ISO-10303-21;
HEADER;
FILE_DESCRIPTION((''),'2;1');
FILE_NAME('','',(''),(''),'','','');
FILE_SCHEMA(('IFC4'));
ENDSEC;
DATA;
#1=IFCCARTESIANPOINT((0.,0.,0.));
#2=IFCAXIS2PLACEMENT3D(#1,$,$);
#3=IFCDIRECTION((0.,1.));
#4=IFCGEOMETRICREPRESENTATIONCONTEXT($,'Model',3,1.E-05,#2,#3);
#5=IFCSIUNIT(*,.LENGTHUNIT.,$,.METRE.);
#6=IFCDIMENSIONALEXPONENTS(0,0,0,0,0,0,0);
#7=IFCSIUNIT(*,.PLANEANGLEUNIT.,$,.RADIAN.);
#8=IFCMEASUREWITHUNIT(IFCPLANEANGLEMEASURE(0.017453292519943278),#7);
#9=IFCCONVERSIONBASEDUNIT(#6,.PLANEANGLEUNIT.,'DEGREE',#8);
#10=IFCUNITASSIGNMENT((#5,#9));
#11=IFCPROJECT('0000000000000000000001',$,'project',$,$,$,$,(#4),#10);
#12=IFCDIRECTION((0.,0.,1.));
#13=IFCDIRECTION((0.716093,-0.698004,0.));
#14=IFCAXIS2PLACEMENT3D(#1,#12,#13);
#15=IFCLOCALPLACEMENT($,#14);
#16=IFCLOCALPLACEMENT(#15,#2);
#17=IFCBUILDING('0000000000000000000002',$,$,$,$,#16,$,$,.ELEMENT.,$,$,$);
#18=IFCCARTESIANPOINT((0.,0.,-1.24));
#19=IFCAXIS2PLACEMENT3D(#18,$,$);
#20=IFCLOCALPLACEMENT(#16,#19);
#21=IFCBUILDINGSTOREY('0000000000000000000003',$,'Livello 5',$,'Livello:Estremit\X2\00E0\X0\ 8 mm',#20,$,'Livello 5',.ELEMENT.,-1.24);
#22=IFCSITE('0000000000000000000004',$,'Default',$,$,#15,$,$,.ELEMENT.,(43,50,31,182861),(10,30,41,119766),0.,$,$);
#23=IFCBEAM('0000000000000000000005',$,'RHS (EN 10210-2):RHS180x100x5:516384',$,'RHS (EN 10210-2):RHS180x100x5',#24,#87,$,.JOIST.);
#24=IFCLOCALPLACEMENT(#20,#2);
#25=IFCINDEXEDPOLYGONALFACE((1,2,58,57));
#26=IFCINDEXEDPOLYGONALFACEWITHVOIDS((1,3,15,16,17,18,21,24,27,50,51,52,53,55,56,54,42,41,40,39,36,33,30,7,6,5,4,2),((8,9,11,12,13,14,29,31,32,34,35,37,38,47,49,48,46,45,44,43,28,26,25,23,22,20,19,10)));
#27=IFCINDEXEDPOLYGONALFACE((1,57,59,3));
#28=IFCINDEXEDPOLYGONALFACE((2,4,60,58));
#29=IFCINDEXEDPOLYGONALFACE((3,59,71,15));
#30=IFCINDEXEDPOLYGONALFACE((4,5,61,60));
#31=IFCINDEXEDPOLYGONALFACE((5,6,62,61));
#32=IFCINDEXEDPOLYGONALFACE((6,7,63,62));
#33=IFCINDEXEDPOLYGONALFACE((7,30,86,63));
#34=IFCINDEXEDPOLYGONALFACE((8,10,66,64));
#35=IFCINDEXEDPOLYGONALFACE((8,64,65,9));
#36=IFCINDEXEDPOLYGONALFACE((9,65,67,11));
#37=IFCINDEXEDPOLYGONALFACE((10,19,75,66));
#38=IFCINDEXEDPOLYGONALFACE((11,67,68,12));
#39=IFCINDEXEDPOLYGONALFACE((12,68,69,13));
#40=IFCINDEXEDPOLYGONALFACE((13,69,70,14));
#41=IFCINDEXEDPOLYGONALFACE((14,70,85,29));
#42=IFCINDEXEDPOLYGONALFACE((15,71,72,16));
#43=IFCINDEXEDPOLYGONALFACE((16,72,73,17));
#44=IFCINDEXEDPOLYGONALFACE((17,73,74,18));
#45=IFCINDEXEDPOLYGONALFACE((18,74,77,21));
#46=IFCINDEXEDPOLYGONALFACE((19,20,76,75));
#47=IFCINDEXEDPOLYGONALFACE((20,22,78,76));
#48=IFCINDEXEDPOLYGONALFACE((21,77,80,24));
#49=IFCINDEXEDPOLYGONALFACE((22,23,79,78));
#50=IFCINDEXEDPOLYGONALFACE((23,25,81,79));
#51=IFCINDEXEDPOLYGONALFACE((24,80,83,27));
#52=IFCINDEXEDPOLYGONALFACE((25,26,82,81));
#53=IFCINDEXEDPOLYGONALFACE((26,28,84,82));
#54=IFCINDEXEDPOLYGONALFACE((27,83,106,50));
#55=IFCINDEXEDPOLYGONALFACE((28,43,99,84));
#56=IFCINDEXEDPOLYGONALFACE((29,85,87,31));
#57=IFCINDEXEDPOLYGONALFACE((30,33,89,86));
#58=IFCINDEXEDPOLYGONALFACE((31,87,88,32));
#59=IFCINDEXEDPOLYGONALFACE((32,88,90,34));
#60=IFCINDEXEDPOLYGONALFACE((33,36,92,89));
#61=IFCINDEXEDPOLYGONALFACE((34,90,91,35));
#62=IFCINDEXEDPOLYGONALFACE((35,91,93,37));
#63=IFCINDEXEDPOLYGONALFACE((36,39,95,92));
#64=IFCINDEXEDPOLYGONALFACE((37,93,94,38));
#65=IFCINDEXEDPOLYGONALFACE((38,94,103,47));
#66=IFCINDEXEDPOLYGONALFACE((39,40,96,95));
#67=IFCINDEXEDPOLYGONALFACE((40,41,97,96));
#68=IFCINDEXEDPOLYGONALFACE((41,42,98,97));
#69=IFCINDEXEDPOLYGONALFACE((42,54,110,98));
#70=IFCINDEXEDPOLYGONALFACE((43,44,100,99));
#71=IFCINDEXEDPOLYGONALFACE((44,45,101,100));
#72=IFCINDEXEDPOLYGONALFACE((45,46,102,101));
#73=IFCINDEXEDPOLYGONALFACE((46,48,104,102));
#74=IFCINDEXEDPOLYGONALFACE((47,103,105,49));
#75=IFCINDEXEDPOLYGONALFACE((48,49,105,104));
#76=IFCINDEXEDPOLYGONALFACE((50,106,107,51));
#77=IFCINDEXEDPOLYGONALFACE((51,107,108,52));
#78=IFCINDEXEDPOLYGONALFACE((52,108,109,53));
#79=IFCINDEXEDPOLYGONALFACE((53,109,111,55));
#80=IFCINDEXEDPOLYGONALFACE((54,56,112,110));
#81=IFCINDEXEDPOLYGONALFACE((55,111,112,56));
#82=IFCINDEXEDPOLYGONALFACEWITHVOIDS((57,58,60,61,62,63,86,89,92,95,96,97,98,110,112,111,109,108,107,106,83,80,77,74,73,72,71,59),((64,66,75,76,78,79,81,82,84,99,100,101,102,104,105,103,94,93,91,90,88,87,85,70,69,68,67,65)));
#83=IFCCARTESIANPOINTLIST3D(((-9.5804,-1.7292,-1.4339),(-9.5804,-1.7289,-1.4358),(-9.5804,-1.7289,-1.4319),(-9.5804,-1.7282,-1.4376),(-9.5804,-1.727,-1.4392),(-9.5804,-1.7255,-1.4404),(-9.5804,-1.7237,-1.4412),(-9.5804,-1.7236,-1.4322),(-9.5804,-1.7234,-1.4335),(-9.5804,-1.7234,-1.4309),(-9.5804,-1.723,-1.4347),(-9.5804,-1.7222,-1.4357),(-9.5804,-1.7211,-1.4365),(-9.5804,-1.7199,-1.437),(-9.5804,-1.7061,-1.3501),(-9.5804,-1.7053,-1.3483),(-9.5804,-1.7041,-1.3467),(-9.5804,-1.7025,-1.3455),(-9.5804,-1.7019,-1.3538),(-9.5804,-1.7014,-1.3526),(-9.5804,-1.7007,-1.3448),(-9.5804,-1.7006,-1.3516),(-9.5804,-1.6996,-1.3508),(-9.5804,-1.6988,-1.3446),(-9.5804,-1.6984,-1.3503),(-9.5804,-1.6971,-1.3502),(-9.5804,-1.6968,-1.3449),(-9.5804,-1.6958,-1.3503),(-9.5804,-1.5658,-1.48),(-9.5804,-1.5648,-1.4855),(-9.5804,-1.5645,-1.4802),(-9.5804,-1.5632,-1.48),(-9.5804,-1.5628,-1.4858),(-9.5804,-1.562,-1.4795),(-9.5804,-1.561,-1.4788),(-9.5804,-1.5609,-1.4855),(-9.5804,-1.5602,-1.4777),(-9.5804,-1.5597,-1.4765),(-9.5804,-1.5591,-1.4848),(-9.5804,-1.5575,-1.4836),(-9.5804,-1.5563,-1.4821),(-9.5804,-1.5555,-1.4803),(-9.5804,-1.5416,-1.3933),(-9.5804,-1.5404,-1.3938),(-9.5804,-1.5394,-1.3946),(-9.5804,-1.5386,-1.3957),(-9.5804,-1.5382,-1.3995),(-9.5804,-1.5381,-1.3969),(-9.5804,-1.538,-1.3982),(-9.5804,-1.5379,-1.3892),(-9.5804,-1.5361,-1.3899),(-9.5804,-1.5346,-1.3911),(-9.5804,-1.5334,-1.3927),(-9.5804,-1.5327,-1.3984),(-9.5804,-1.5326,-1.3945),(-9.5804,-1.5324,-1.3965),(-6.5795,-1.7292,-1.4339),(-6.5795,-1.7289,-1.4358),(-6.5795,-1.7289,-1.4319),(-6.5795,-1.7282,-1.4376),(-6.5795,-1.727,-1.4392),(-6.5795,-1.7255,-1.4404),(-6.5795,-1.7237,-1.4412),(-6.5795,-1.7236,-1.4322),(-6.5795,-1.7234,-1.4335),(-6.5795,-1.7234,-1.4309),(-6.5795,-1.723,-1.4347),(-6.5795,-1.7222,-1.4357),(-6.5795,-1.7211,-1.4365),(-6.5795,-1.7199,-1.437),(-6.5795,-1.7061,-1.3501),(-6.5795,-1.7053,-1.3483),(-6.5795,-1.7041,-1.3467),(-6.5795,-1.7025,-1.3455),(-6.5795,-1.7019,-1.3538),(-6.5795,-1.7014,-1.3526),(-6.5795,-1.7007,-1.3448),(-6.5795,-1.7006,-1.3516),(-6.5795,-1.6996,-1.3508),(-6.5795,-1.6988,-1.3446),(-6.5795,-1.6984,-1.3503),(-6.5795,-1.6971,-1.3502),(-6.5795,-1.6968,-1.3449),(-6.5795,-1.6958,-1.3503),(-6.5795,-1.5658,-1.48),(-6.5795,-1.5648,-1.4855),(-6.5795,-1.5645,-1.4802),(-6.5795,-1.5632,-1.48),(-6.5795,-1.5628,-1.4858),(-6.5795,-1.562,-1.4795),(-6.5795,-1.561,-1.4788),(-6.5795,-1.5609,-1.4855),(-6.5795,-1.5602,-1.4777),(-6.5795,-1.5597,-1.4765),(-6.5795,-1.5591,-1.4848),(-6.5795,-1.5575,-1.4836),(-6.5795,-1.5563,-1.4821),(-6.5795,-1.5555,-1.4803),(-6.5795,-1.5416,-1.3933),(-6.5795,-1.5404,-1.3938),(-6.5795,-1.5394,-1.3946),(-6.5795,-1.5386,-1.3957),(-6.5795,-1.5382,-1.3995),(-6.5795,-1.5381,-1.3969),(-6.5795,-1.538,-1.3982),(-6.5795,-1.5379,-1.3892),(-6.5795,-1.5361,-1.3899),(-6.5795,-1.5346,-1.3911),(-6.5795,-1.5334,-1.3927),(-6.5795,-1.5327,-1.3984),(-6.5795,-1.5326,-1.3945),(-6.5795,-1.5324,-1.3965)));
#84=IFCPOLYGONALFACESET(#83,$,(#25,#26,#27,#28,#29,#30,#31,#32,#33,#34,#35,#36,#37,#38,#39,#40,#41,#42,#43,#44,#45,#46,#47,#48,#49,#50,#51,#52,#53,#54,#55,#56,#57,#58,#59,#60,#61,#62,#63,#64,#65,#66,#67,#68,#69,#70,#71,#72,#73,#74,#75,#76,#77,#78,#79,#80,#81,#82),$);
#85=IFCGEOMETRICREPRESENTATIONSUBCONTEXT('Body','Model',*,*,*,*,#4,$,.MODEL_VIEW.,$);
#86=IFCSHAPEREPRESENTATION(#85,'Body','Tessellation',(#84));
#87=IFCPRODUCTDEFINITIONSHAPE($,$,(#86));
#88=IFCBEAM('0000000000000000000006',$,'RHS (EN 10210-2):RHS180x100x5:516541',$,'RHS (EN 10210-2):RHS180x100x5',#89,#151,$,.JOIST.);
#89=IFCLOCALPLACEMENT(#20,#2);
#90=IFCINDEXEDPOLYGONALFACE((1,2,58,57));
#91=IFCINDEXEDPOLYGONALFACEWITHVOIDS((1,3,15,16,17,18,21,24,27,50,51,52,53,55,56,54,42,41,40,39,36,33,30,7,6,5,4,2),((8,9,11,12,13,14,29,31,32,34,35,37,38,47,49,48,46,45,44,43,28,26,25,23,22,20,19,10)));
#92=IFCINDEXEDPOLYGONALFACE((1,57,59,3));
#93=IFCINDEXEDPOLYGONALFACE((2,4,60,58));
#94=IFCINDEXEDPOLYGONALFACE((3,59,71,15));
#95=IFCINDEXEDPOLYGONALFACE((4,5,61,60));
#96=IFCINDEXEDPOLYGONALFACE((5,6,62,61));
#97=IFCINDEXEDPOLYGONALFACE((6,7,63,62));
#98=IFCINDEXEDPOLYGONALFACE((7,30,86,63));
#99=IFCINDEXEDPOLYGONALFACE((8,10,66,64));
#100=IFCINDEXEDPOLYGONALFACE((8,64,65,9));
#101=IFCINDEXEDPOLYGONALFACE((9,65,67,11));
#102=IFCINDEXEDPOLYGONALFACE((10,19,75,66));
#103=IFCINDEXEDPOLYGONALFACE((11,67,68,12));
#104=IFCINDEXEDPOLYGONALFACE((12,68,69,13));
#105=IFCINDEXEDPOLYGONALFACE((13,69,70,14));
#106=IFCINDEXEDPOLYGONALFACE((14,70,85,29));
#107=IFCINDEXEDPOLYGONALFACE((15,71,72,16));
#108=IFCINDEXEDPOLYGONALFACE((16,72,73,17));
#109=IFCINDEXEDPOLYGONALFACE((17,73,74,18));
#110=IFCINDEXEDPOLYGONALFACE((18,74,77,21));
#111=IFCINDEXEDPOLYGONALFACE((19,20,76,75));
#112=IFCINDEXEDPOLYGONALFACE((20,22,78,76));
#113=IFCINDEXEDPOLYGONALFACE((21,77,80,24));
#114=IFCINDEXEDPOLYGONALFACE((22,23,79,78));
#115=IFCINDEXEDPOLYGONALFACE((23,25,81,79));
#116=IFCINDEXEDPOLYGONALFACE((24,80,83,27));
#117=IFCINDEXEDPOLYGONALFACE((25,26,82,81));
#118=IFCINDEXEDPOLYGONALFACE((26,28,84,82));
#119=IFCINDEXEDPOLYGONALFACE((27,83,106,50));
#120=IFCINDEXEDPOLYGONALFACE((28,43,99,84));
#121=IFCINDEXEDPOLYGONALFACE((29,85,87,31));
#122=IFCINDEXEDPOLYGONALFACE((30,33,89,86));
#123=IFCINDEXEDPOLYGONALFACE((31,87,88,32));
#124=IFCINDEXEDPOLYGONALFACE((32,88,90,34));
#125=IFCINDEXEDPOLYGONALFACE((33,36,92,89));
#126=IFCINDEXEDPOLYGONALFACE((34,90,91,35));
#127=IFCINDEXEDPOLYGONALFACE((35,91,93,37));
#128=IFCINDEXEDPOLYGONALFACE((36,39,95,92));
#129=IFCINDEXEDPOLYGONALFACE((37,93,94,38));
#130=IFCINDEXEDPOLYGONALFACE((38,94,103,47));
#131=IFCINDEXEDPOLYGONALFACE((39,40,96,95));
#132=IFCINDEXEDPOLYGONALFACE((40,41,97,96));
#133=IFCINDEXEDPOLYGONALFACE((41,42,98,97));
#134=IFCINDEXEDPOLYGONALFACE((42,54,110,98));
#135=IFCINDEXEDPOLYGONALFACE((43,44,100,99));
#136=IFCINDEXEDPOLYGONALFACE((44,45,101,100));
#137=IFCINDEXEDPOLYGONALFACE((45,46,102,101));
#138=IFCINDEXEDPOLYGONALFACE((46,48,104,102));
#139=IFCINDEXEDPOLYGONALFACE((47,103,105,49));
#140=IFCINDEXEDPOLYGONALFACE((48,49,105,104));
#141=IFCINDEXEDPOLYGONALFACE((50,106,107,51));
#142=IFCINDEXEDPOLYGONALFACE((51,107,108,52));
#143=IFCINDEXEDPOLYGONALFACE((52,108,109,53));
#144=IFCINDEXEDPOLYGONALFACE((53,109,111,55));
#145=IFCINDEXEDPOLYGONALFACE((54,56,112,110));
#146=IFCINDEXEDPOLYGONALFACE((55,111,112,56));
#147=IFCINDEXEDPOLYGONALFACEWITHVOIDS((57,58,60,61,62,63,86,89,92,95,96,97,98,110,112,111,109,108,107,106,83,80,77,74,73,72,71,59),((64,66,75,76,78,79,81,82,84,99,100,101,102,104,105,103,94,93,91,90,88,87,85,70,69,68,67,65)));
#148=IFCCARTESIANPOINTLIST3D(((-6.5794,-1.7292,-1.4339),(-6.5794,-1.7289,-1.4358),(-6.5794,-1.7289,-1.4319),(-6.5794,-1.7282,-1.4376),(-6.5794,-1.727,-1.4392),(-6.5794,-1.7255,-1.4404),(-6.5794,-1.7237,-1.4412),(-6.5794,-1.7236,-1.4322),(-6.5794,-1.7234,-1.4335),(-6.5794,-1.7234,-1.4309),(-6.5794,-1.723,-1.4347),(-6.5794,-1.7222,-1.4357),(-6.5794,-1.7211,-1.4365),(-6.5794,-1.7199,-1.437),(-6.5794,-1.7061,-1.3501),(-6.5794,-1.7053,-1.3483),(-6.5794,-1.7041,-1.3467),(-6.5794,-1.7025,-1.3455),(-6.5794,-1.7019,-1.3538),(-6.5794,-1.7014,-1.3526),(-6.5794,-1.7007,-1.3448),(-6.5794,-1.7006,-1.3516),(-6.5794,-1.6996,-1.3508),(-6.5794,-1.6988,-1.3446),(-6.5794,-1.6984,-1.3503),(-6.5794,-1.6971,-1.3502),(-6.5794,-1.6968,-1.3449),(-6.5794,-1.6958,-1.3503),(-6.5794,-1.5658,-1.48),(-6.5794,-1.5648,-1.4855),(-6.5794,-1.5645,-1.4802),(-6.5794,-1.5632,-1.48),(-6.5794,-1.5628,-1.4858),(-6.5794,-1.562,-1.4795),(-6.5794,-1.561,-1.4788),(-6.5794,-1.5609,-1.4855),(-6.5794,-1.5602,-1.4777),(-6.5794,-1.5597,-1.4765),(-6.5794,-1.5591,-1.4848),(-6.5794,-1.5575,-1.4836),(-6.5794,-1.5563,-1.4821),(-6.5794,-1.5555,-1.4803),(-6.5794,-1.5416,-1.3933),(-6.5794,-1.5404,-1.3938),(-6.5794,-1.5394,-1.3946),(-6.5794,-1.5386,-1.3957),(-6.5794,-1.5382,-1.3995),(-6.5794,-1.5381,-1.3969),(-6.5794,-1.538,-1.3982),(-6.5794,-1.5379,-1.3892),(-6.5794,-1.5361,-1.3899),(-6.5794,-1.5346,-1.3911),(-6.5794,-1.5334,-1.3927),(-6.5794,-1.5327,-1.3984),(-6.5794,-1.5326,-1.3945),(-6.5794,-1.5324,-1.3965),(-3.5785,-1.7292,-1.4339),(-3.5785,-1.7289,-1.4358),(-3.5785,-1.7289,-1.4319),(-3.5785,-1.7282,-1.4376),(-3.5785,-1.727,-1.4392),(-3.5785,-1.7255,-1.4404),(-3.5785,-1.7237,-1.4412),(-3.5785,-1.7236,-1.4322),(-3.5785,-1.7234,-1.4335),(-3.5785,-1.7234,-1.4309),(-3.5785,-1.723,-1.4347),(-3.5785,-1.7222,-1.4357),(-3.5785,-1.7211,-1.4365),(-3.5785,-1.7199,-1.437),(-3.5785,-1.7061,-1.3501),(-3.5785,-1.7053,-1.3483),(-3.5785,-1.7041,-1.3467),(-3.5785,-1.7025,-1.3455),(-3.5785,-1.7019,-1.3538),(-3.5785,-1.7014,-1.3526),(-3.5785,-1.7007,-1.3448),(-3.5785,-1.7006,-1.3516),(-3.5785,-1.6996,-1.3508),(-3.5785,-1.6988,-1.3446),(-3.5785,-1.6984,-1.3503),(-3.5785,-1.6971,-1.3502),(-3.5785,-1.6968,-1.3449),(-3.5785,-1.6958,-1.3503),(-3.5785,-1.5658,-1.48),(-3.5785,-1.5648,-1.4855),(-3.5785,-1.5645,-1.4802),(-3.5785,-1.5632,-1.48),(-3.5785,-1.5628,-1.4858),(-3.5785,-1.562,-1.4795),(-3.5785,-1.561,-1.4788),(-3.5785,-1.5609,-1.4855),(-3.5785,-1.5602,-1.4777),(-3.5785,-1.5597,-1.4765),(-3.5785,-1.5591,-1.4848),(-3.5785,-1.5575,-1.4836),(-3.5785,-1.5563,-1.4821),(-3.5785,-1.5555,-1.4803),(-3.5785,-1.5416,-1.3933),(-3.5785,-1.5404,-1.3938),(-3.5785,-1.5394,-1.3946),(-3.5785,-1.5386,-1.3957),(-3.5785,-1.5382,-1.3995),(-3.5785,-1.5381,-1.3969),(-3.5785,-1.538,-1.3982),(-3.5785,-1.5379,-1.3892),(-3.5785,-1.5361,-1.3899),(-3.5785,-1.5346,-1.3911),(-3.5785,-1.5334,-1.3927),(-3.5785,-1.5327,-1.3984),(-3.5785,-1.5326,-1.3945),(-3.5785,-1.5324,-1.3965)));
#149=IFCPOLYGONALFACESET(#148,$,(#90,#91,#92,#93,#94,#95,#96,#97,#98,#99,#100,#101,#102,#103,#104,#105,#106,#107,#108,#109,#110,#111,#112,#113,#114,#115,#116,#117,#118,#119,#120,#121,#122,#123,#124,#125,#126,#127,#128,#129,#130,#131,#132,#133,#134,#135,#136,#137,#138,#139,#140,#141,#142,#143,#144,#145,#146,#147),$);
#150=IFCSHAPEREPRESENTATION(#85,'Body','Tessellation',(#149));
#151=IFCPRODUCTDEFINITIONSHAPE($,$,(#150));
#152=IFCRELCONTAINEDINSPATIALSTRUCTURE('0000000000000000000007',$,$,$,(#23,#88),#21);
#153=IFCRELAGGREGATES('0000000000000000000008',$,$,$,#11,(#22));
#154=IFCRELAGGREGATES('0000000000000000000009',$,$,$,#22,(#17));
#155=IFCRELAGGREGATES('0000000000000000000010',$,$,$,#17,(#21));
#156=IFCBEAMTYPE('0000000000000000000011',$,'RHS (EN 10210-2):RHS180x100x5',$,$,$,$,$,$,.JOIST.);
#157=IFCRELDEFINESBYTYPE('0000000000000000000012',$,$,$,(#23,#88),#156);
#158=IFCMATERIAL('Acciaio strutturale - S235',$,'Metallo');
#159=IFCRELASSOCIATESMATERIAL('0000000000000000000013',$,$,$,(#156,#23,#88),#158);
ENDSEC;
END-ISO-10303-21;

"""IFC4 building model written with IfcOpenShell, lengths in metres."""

from ifc_helpers import new_model, entity, si_unit, converted_unit, direction, frame, origin, place, context, subcontext, project, spatial, line, arc, indexed_curve, outline, extrude, source, transform, mapped, material, type_object, type_shapes, element, save


model = new_model("IFC4")

# Units and contexts
model_context = context("Model", 3, precision=1e-05, world=origin(), true_north=direction((0.0, 1.0)))
body_context = subcontext(model_context, "Body", "Model", "MODEL_VIEW")
ifc_project = project(units=[si_unit("LENGTHUNIT", "METRE"), converted_unit("PLANEANGLEUNIT", "DEGREE", entity("IfcPlaneAngleMeasure", 0.017453292519943278), si_unit("PLANEANGLEUNIT", "RADIAN"), dimensions=[0, 0, 0, 0, 0, 0, 0])], contexts=[model_context])

# Site, building, storey
site_placement = place(None, frame((0.0, 0.0, 0.0), z_axis=(0.0, 0.0, 1.0), x_axis=(0.716093, -0.698004, 0.0)))
site = spatial("IfcSite", under=ifc_project, at=site_placement, Name="Default", CompositionType="ELEMENT", RefLatitude=(43, 50, 31, 182861), RefLongitude=(10, 30, 41, 119766), RefElevation=0.0)
building_placement = place(site_placement, origin())
building = spatial("IfcBuilding", under=site, at=building_placement, CompositionType="ELEMENT")
storey_placement = place(building_placement, frame((0.0, 0.0, -1.24)))
storey = spatial("IfcBuildingStorey", under=building, at=storey_placement, Name="Livello 5", ObjectType="Livello:Estremità 8 mm", LongName="Livello 5", CompositionType="ELEMENT", Elevation=-1.24)

# Beams
ifc_material = material(Name="Acciaio strutturale - S235", Category="Metallo")
beam_type_1 = type_object("IfcBeamType", Name="RHS (EN 10210-2):RHS180x100x5", PredefinedType="JOIST", material=ifc_material)
shared_shape_1 = source(origin(), body_context, "Body", "SweptSolid", [
    extrude(outline(indexed_curve([(-0.05, -0.0825), (-0.0478, -0.0878), (-0.0425, -0.09), (0.0425, -0.09), (0.0478, -0.0878), (0.05, -0.0825), (0.05, 0.0825), (0.0478, 0.0878), (0.0425, 0.09), (-0.0425, 0.09), (-0.0478, 0.0878), (-0.05, 0.0825)], segments=[arc(1, 2, 3), line(3, 4), arc(4, 5, 6), line(6, 7), arc(7, 8, 9), line(9, 10), arc(10, 11, 12), line(12, 1)], self_intersect=False), holes=[indexed_curve([(0.04, -0.085), (-0.04, -0.085), (-0.0435, -0.0835), (-0.045, -0.08), (-0.045, 0.08), (-0.0435, 0.0835), (-0.04, 0.085), (0.04, 0.085), (0.0435, 0.0835), (0.045, 0.08), (0.045, -0.08), (0.0435, -0.0835)], segments=[line(1, 2), arc(2, 3, 4), line(4, 5), arc(5, 6, 7), line(7, 8), arc(8, 9, 10), line(10, 11), arc(11, 12, 1)], self_intersect=False)]), frame((-1.5005, 0.0, 0.0), z_axis=(1.0, 0.0, 0.0), x_axis=(0.0, -1.0, 0.0)), (0.0, 0.0, 1.0), 3.0009),
])
type_shapes(beam_type_1, [shared_shape_1])
for number, where, z_axis, x_axis, name in (
    (1, (-8.0799, -1.6308, -1.4152), (0.0, 0.963256, -0.268584), (-1.0, 0.0, 0.0), "RHS (EN 10210-2):RHS180x100x5:516384"),
    (2, (-5.0789, -1.6308, -1.4152), (0.0, 0.963256, -0.268584), (-1.0, 0.0, 0.0), "RHS (EN 10210-2):RHS180x100x5:516541"),
):
    element("IfcBeam", number, at=place(storey_placement, frame(where, z_axis=z_axis, x_axis=x_axis)), inside=storey, type_object=beam_type_1, material=ifc_material, Name=name, ObjectType="RHS (EN 10210-2):RHS180x100x5", PredefinedType="JOIST", context=body_context, shape_type="MappedRepresentation", body=[
        mapped(shared_shape_1, transform((0.0, 0.0, 0.0), scale=1.0)),
    ])

save(model, "model.ifc")
